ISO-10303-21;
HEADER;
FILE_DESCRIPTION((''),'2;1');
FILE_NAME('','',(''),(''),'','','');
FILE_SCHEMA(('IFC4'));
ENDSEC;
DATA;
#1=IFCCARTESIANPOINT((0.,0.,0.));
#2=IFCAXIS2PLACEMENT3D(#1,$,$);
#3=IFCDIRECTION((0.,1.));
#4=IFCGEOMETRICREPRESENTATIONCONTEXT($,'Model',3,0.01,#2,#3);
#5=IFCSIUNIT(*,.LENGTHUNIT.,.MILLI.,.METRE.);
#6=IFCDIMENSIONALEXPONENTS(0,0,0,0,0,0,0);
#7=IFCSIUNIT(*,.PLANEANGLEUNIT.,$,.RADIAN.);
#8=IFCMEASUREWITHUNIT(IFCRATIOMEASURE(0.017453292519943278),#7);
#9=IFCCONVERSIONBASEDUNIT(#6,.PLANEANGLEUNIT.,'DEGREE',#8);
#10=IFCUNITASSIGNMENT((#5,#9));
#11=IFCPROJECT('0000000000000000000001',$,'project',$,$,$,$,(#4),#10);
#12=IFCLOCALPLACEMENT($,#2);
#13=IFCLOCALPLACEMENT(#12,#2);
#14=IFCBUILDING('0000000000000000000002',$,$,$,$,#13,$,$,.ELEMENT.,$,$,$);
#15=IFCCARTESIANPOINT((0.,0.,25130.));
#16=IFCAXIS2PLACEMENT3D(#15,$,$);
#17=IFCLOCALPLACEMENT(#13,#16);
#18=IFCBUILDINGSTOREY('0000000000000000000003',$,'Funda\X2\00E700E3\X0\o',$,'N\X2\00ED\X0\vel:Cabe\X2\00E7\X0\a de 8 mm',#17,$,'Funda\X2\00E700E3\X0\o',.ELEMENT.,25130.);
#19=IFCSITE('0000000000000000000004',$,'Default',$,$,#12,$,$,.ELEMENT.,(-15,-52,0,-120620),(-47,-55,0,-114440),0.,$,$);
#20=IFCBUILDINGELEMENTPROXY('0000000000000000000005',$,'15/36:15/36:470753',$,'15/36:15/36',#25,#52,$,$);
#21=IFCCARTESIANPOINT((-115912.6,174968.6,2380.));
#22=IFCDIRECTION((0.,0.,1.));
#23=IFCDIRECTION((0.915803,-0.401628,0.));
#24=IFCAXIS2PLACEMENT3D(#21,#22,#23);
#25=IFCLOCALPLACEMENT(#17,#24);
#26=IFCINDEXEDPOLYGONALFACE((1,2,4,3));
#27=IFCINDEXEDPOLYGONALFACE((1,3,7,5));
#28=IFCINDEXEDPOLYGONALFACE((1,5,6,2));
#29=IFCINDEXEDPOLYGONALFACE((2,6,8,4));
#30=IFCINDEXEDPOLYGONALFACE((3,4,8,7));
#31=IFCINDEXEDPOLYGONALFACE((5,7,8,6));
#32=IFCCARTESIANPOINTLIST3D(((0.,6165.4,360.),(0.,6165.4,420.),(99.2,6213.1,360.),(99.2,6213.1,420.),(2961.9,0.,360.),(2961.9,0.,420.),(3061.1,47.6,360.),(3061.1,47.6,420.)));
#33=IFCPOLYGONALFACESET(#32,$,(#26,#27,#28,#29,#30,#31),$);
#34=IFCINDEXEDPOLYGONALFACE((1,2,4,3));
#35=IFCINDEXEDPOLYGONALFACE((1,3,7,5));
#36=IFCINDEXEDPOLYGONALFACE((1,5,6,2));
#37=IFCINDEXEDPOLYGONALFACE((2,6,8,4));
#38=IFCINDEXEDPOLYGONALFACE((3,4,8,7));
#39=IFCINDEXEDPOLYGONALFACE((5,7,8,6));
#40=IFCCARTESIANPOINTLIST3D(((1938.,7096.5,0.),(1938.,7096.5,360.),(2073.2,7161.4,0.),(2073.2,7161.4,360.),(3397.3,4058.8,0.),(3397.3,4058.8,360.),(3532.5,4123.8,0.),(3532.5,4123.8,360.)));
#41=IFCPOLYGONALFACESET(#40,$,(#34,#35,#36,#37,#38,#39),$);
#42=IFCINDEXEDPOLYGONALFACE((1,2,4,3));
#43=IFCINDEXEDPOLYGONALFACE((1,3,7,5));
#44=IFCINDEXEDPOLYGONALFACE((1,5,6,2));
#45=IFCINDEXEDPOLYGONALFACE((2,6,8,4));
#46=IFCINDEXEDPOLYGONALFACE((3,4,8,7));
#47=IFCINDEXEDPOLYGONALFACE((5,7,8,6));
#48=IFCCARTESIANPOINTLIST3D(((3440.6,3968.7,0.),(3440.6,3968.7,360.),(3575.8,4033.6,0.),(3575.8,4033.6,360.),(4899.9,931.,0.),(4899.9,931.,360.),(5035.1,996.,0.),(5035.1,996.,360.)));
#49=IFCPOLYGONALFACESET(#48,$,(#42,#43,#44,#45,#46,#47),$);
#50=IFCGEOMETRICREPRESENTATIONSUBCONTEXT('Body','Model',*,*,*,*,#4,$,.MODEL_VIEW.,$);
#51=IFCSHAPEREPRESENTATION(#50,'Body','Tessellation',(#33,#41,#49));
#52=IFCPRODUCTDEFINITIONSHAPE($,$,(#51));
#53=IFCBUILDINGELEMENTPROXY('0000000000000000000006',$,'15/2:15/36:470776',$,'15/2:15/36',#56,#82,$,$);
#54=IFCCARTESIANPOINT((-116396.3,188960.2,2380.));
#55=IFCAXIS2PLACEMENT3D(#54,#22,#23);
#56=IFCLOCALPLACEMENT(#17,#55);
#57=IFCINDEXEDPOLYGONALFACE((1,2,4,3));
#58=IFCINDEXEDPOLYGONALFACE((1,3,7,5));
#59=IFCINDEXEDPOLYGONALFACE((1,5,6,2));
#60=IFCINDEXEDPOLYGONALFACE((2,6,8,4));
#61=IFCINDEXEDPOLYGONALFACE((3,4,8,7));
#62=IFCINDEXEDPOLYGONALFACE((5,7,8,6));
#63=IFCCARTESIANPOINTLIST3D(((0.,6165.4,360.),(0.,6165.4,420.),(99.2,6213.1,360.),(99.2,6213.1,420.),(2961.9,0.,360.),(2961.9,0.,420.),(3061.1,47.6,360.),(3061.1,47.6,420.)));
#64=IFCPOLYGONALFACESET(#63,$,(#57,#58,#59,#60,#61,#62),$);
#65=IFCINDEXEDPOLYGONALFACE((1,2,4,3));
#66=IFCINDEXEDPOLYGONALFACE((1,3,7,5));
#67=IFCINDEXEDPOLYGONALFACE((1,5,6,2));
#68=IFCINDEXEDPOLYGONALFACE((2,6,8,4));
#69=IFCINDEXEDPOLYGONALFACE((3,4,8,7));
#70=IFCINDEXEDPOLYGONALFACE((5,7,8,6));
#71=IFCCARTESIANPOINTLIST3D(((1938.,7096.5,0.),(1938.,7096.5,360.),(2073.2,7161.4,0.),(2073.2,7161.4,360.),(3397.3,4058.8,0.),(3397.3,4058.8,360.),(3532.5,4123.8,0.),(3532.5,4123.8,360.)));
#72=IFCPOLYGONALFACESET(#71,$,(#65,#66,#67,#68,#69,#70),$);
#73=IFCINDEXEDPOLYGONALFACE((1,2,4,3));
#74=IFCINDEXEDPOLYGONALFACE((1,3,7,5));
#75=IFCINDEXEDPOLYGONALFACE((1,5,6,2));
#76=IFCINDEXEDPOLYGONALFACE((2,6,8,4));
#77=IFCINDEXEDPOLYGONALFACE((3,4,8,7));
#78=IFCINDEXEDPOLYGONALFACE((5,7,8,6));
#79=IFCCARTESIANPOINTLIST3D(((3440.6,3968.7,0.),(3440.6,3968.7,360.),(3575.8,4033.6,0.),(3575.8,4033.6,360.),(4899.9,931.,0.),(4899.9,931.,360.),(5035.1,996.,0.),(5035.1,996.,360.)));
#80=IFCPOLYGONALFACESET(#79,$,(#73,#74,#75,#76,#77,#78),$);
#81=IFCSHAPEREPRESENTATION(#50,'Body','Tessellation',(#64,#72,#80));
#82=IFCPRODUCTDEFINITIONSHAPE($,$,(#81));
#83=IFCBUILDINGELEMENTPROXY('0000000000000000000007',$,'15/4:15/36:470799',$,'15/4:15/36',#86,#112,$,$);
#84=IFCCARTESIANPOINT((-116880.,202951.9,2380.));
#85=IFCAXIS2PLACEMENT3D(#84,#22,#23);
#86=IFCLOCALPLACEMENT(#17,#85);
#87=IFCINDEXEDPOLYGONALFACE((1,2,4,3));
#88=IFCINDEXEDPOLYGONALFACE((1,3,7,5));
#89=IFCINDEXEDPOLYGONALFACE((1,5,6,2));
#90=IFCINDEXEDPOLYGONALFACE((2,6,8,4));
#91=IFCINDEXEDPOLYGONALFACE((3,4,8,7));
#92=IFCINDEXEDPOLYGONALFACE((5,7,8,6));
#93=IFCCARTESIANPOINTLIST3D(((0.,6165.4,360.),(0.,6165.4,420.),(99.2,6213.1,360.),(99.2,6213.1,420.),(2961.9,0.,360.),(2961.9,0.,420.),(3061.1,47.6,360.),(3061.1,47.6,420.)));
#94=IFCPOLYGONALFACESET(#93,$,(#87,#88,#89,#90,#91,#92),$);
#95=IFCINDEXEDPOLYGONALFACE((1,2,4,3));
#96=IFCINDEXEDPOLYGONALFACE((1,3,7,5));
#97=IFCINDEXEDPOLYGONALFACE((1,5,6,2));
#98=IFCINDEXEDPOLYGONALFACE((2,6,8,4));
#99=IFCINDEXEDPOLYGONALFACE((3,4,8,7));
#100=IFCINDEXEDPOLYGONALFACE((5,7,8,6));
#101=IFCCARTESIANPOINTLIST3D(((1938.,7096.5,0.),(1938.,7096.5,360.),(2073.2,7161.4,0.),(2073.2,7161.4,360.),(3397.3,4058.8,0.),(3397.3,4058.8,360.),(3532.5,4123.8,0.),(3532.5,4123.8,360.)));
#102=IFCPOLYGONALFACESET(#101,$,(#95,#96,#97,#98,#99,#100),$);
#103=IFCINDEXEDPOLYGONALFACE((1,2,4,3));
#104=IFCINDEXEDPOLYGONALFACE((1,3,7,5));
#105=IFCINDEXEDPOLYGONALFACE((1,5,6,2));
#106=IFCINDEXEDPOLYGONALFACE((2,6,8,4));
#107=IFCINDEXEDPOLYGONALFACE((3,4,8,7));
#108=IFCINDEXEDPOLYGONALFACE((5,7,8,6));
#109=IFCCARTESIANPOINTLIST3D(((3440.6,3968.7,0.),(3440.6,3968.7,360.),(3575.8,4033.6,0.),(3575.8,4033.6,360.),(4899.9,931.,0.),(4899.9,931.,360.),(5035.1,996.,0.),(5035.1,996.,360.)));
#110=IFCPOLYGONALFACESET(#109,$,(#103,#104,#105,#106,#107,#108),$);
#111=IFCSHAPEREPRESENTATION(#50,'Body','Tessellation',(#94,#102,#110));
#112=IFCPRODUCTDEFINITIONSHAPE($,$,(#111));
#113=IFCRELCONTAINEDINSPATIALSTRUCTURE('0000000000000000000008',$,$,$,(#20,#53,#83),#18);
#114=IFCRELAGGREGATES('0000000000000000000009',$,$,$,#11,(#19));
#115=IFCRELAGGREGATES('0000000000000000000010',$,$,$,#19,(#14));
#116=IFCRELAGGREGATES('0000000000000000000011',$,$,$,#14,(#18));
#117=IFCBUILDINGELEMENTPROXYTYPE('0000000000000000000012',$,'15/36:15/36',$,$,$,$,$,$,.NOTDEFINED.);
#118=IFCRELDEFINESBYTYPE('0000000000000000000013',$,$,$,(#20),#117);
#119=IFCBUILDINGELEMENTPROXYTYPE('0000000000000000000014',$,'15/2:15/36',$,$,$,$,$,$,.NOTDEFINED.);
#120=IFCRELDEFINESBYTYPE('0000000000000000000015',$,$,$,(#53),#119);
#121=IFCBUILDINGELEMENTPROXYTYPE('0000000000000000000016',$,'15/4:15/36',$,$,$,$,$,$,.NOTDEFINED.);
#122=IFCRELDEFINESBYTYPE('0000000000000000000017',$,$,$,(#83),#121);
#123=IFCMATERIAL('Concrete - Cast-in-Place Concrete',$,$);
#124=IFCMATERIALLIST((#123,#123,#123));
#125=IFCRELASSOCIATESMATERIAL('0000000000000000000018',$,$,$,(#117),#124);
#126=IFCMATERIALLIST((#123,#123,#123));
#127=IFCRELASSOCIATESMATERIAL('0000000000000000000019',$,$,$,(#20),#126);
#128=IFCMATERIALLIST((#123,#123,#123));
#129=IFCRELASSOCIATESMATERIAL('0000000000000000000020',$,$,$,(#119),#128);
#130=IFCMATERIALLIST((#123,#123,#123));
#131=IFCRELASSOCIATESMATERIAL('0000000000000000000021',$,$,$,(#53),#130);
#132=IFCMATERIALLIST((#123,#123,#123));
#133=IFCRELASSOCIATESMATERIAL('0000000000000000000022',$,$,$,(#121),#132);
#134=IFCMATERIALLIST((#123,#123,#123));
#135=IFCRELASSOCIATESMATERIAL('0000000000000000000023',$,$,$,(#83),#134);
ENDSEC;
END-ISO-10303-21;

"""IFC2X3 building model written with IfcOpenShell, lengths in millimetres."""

from ifc_helpers import new_model, entity, si_unit, converted_unit, direction, frame, frame_2d, origin, place, context, subcontext, project, spatial, rectangle, extrude, source, transform, mapped, material, material_list, type_object, type_shapes, element, save


model = new_model("IFC2X3")

# Units and contexts
model_context = context("Model", 3, precision=0.01, world=origin(), true_north=direction((0.0, 1.0)))
body_context = subcontext(model_context, "Body", "Model", "MODEL_VIEW")
ifc_project = project(units=[si_unit("LENGTHUNIT", "METRE", prefix="MILLI"), converted_unit("PLANEANGLEUNIT", "DEGREE", entity("IfcRatioMeasure", 0.017453292519943278), si_unit("PLANEANGLEUNIT", "RADIAN"), dimensions=[0, 0, 0, 0, 0, 0, 0])], contexts=[model_context])

# Site, building, storey
site_placement = place(None, origin())
site = spatial("IfcSite", under=ifc_project, at=site_placement, Name="Default", CompositionType="ELEMENT", RefLatitude=(-15, -52, 0, -120620), RefLongitude=(-47, -55, 0, -114440), RefElevation=0.0)
building_placement = place(site_placement, origin())
building = spatial("IfcBuilding", under=site, at=building_placement, CompositionType="ELEMENT")
storey_placement = place(building_placement, frame((0.0, 0.0, 25130.0)))
storey = spatial("IfcBuildingStorey", under=building, at=storey_placement, Name="Fundação", ObjectType="Nível:Cabeça de 8 mm", LongName="Fundação", CompositionType="ELEMENT", Elevation=25130.0)

# Building element proxies
ifc_material_1 = material(Name="Concrete - Cast-in-Place Concrete")
ifc_material_list_1 = material_list([ifc_material_1, ifc_material_1, ifc_material_1])
ifc_material_list_2 = material_list([ifc_material_1, ifc_material_1, ifc_material_1])
building_element_proxy_type_1 = type_object("IfcBuildingElementProxyType", Name="15/36:15/36", PredefinedType="NOTDEFINED", material=ifc_material_list_2)
shared_shape_1 = source(origin(), body_context, "Body", "SweptSolid", [
    extrude(rectangle(XDim=110.0, YDim=6840.0, at=frame_2d((0.0, 0.0), x_axis=(1.0, 0.0))), frame((1530.5, 3106.5, 360.0), z_axis=(0.0, 0.0, 1.0), x_axis=(0.90138, 0.43303, 0.0)), (0.0, 0.0, 1.0), 60.0),
    extrude(rectangle(XDim=3370.0, YDim=150.0, at=frame_2d((0.0, 0.0), x_axis=(1.0, 0.0))), frame((2735.2, 5610.1, 0.0), z_axis=(0.0, 0.0, 1.0), x_axis=(0.43303, -0.90138, 0.0)), (0.0, 0.0, 1.0), 360.0),
    extrude(rectangle(XDim=3370.0, YDim=150.0, at=frame_2d((0.0, 0.0), x_axis=(1.0, 0.0))), frame((4237.8, 2482.3, 0.0), z_axis=(0.0, 0.0, 1.0), x_axis=(0.43303, -0.90138, 0.0)), (0.0, 0.0, 1.0), 360.0),
])
type_shapes(building_element_proxy_type_1, [shared_shape_1])
proxy_1_placement = place(storey_placement, frame((-115912.6, 174968.6, 2380.0), z_axis=(0.0, 0.0, 1.0), x_axis=(0.915803, -0.401628, 0.0)))
element("IfcBuildingElementProxy", 1, at=proxy_1_placement, inside=storey, type_object=building_element_proxy_type_1, material=ifc_material_list_1, Name="15/36:15/36:470753", ObjectType="15/36:15/36", context=body_context, shape_type="MappedRepresentation", body=[
    mapped(shared_shape_1, transform((0.0, 0.0, 0.0), scale=1.0)),
])
ifc_material_list_3 = material_list([ifc_material_1, ifc_material_1, ifc_material_1])
ifc_material_list_4 = material_list([ifc_material_1, ifc_material_1, ifc_material_1])
building_element_proxy_type_2 = type_object("IfcBuildingElementProxyType", Name="15/2:15/36", PredefinedType="NOTDEFINED", material=ifc_material_list_4)
shared_shape_2 = source(origin(), body_context, "Body", "SweptSolid", [
    extrude(rectangle(XDim=110.0, YDim=6840.0, at=frame_2d((0.0, 0.0), x_axis=(1.0, 0.0))), frame((1530.5, 3106.5, 360.0), z_axis=(0.0, 0.0, 1.0), x_axis=(0.90138, 0.43303, 0.0)), (0.0, 0.0, 1.0), 60.0),
    extrude(rectangle(XDim=3370.0, YDim=150.0, at=frame_2d((0.0, 0.0), x_axis=(1.0, 0.0))), frame((2735.2, 5610.1, 0.0), z_axis=(0.0, 0.0, 1.0), x_axis=(0.43303, -0.90138, 0.0)), (0.0, 0.0, 1.0), 360.0),
    extrude(rectangle(XDim=3370.0, YDim=150.0, at=frame_2d((0.0, 0.0), x_axis=(1.0, 0.0))), frame((4237.8, 2482.3, 0.0), z_axis=(0.0, 0.0, 1.0), x_axis=(0.43303, -0.90138, 0.0)), (0.0, 0.0, 1.0), 360.0),
])
type_shapes(building_element_proxy_type_2, [shared_shape_2])
proxy_2_placement = place(storey_placement, frame((-116396.3, 188960.2, 2380.0), z_axis=(0.0, 0.0, 1.0), x_axis=(0.915803, -0.401628, 0.0)))
element("IfcBuildingElementProxy", 2, at=proxy_2_placement, inside=storey, type_object=building_element_proxy_type_2, material=ifc_material_list_3, Name="15/2:15/36:470776", ObjectType="15/2:15/36", context=body_context, shape_type="MappedRepresentation", body=[
    mapped(shared_shape_2, transform((0.0, 0.0, 0.0), scale=1.0)),
])
ifc_material_list_5 = material_list([ifc_material_1, ifc_material_1, ifc_material_1])
ifc_material_list_6 = material_list([ifc_material_1, ifc_material_1, ifc_material_1])
building_element_proxy_type_3 = type_object("IfcBuildingElementProxyType", Name="15/4:15/36", PredefinedType="NOTDEFINED", material=ifc_material_list_6)
shared_shape_3 = source(origin(), body_context, "Body", "SweptSolid", [
    extrude(rectangle(XDim=110.0, YDim=6840.0, at=frame_2d((0.0, 0.0), x_axis=(1.0, 0.0))), frame((1530.5, 3106.5, 360.0), z_axis=(0.0, 0.0, 1.0), x_axis=(0.90138, 0.43303, 0.0)), (0.0, 0.0, 1.0), 60.0),
    extrude(rectangle(XDim=3370.0, YDim=150.0, at=frame_2d((0.0, 0.0), x_axis=(1.0, 0.0))), frame((2735.2, 5610.1, 0.0), z_axis=(0.0, 0.0, 1.0), x_axis=(0.43303, -0.90138, 0.0)), (0.0, 0.0, 1.0), 360.0),
    extrude(rectangle(XDim=3370.0, YDim=150.0, at=frame_2d((0.0, 0.0), x_axis=(1.0, 0.0))), frame((4237.8, 2482.3, 0.0), z_axis=(0.0, 0.0, 1.0), x_axis=(0.43303, -0.90138, 0.0)), (0.0, 0.0, 1.0), 360.0),
])
type_shapes(building_element_proxy_type_3, [shared_shape_3])
proxy_3_placement = place(storey_placement, frame((-116880.0, 202951.9, 2380.0), z_axis=(0.0, 0.0, 1.0), x_axis=(0.915803, -0.401628, 0.0)))
element("IfcBuildingElementProxy", 3, at=proxy_3_placement, inside=storey, type_object=building_element_proxy_type_3, material=ifc_material_list_5, Name="15/4:15/36:470799", ObjectType="15/4:15/36", context=body_context, shape_type="MappedRepresentation", body=[
    mapped(shared_shape_3, transform((0.0, 0.0, 0.0), scale=1.0)),
])

save(model, "model.ifc")
